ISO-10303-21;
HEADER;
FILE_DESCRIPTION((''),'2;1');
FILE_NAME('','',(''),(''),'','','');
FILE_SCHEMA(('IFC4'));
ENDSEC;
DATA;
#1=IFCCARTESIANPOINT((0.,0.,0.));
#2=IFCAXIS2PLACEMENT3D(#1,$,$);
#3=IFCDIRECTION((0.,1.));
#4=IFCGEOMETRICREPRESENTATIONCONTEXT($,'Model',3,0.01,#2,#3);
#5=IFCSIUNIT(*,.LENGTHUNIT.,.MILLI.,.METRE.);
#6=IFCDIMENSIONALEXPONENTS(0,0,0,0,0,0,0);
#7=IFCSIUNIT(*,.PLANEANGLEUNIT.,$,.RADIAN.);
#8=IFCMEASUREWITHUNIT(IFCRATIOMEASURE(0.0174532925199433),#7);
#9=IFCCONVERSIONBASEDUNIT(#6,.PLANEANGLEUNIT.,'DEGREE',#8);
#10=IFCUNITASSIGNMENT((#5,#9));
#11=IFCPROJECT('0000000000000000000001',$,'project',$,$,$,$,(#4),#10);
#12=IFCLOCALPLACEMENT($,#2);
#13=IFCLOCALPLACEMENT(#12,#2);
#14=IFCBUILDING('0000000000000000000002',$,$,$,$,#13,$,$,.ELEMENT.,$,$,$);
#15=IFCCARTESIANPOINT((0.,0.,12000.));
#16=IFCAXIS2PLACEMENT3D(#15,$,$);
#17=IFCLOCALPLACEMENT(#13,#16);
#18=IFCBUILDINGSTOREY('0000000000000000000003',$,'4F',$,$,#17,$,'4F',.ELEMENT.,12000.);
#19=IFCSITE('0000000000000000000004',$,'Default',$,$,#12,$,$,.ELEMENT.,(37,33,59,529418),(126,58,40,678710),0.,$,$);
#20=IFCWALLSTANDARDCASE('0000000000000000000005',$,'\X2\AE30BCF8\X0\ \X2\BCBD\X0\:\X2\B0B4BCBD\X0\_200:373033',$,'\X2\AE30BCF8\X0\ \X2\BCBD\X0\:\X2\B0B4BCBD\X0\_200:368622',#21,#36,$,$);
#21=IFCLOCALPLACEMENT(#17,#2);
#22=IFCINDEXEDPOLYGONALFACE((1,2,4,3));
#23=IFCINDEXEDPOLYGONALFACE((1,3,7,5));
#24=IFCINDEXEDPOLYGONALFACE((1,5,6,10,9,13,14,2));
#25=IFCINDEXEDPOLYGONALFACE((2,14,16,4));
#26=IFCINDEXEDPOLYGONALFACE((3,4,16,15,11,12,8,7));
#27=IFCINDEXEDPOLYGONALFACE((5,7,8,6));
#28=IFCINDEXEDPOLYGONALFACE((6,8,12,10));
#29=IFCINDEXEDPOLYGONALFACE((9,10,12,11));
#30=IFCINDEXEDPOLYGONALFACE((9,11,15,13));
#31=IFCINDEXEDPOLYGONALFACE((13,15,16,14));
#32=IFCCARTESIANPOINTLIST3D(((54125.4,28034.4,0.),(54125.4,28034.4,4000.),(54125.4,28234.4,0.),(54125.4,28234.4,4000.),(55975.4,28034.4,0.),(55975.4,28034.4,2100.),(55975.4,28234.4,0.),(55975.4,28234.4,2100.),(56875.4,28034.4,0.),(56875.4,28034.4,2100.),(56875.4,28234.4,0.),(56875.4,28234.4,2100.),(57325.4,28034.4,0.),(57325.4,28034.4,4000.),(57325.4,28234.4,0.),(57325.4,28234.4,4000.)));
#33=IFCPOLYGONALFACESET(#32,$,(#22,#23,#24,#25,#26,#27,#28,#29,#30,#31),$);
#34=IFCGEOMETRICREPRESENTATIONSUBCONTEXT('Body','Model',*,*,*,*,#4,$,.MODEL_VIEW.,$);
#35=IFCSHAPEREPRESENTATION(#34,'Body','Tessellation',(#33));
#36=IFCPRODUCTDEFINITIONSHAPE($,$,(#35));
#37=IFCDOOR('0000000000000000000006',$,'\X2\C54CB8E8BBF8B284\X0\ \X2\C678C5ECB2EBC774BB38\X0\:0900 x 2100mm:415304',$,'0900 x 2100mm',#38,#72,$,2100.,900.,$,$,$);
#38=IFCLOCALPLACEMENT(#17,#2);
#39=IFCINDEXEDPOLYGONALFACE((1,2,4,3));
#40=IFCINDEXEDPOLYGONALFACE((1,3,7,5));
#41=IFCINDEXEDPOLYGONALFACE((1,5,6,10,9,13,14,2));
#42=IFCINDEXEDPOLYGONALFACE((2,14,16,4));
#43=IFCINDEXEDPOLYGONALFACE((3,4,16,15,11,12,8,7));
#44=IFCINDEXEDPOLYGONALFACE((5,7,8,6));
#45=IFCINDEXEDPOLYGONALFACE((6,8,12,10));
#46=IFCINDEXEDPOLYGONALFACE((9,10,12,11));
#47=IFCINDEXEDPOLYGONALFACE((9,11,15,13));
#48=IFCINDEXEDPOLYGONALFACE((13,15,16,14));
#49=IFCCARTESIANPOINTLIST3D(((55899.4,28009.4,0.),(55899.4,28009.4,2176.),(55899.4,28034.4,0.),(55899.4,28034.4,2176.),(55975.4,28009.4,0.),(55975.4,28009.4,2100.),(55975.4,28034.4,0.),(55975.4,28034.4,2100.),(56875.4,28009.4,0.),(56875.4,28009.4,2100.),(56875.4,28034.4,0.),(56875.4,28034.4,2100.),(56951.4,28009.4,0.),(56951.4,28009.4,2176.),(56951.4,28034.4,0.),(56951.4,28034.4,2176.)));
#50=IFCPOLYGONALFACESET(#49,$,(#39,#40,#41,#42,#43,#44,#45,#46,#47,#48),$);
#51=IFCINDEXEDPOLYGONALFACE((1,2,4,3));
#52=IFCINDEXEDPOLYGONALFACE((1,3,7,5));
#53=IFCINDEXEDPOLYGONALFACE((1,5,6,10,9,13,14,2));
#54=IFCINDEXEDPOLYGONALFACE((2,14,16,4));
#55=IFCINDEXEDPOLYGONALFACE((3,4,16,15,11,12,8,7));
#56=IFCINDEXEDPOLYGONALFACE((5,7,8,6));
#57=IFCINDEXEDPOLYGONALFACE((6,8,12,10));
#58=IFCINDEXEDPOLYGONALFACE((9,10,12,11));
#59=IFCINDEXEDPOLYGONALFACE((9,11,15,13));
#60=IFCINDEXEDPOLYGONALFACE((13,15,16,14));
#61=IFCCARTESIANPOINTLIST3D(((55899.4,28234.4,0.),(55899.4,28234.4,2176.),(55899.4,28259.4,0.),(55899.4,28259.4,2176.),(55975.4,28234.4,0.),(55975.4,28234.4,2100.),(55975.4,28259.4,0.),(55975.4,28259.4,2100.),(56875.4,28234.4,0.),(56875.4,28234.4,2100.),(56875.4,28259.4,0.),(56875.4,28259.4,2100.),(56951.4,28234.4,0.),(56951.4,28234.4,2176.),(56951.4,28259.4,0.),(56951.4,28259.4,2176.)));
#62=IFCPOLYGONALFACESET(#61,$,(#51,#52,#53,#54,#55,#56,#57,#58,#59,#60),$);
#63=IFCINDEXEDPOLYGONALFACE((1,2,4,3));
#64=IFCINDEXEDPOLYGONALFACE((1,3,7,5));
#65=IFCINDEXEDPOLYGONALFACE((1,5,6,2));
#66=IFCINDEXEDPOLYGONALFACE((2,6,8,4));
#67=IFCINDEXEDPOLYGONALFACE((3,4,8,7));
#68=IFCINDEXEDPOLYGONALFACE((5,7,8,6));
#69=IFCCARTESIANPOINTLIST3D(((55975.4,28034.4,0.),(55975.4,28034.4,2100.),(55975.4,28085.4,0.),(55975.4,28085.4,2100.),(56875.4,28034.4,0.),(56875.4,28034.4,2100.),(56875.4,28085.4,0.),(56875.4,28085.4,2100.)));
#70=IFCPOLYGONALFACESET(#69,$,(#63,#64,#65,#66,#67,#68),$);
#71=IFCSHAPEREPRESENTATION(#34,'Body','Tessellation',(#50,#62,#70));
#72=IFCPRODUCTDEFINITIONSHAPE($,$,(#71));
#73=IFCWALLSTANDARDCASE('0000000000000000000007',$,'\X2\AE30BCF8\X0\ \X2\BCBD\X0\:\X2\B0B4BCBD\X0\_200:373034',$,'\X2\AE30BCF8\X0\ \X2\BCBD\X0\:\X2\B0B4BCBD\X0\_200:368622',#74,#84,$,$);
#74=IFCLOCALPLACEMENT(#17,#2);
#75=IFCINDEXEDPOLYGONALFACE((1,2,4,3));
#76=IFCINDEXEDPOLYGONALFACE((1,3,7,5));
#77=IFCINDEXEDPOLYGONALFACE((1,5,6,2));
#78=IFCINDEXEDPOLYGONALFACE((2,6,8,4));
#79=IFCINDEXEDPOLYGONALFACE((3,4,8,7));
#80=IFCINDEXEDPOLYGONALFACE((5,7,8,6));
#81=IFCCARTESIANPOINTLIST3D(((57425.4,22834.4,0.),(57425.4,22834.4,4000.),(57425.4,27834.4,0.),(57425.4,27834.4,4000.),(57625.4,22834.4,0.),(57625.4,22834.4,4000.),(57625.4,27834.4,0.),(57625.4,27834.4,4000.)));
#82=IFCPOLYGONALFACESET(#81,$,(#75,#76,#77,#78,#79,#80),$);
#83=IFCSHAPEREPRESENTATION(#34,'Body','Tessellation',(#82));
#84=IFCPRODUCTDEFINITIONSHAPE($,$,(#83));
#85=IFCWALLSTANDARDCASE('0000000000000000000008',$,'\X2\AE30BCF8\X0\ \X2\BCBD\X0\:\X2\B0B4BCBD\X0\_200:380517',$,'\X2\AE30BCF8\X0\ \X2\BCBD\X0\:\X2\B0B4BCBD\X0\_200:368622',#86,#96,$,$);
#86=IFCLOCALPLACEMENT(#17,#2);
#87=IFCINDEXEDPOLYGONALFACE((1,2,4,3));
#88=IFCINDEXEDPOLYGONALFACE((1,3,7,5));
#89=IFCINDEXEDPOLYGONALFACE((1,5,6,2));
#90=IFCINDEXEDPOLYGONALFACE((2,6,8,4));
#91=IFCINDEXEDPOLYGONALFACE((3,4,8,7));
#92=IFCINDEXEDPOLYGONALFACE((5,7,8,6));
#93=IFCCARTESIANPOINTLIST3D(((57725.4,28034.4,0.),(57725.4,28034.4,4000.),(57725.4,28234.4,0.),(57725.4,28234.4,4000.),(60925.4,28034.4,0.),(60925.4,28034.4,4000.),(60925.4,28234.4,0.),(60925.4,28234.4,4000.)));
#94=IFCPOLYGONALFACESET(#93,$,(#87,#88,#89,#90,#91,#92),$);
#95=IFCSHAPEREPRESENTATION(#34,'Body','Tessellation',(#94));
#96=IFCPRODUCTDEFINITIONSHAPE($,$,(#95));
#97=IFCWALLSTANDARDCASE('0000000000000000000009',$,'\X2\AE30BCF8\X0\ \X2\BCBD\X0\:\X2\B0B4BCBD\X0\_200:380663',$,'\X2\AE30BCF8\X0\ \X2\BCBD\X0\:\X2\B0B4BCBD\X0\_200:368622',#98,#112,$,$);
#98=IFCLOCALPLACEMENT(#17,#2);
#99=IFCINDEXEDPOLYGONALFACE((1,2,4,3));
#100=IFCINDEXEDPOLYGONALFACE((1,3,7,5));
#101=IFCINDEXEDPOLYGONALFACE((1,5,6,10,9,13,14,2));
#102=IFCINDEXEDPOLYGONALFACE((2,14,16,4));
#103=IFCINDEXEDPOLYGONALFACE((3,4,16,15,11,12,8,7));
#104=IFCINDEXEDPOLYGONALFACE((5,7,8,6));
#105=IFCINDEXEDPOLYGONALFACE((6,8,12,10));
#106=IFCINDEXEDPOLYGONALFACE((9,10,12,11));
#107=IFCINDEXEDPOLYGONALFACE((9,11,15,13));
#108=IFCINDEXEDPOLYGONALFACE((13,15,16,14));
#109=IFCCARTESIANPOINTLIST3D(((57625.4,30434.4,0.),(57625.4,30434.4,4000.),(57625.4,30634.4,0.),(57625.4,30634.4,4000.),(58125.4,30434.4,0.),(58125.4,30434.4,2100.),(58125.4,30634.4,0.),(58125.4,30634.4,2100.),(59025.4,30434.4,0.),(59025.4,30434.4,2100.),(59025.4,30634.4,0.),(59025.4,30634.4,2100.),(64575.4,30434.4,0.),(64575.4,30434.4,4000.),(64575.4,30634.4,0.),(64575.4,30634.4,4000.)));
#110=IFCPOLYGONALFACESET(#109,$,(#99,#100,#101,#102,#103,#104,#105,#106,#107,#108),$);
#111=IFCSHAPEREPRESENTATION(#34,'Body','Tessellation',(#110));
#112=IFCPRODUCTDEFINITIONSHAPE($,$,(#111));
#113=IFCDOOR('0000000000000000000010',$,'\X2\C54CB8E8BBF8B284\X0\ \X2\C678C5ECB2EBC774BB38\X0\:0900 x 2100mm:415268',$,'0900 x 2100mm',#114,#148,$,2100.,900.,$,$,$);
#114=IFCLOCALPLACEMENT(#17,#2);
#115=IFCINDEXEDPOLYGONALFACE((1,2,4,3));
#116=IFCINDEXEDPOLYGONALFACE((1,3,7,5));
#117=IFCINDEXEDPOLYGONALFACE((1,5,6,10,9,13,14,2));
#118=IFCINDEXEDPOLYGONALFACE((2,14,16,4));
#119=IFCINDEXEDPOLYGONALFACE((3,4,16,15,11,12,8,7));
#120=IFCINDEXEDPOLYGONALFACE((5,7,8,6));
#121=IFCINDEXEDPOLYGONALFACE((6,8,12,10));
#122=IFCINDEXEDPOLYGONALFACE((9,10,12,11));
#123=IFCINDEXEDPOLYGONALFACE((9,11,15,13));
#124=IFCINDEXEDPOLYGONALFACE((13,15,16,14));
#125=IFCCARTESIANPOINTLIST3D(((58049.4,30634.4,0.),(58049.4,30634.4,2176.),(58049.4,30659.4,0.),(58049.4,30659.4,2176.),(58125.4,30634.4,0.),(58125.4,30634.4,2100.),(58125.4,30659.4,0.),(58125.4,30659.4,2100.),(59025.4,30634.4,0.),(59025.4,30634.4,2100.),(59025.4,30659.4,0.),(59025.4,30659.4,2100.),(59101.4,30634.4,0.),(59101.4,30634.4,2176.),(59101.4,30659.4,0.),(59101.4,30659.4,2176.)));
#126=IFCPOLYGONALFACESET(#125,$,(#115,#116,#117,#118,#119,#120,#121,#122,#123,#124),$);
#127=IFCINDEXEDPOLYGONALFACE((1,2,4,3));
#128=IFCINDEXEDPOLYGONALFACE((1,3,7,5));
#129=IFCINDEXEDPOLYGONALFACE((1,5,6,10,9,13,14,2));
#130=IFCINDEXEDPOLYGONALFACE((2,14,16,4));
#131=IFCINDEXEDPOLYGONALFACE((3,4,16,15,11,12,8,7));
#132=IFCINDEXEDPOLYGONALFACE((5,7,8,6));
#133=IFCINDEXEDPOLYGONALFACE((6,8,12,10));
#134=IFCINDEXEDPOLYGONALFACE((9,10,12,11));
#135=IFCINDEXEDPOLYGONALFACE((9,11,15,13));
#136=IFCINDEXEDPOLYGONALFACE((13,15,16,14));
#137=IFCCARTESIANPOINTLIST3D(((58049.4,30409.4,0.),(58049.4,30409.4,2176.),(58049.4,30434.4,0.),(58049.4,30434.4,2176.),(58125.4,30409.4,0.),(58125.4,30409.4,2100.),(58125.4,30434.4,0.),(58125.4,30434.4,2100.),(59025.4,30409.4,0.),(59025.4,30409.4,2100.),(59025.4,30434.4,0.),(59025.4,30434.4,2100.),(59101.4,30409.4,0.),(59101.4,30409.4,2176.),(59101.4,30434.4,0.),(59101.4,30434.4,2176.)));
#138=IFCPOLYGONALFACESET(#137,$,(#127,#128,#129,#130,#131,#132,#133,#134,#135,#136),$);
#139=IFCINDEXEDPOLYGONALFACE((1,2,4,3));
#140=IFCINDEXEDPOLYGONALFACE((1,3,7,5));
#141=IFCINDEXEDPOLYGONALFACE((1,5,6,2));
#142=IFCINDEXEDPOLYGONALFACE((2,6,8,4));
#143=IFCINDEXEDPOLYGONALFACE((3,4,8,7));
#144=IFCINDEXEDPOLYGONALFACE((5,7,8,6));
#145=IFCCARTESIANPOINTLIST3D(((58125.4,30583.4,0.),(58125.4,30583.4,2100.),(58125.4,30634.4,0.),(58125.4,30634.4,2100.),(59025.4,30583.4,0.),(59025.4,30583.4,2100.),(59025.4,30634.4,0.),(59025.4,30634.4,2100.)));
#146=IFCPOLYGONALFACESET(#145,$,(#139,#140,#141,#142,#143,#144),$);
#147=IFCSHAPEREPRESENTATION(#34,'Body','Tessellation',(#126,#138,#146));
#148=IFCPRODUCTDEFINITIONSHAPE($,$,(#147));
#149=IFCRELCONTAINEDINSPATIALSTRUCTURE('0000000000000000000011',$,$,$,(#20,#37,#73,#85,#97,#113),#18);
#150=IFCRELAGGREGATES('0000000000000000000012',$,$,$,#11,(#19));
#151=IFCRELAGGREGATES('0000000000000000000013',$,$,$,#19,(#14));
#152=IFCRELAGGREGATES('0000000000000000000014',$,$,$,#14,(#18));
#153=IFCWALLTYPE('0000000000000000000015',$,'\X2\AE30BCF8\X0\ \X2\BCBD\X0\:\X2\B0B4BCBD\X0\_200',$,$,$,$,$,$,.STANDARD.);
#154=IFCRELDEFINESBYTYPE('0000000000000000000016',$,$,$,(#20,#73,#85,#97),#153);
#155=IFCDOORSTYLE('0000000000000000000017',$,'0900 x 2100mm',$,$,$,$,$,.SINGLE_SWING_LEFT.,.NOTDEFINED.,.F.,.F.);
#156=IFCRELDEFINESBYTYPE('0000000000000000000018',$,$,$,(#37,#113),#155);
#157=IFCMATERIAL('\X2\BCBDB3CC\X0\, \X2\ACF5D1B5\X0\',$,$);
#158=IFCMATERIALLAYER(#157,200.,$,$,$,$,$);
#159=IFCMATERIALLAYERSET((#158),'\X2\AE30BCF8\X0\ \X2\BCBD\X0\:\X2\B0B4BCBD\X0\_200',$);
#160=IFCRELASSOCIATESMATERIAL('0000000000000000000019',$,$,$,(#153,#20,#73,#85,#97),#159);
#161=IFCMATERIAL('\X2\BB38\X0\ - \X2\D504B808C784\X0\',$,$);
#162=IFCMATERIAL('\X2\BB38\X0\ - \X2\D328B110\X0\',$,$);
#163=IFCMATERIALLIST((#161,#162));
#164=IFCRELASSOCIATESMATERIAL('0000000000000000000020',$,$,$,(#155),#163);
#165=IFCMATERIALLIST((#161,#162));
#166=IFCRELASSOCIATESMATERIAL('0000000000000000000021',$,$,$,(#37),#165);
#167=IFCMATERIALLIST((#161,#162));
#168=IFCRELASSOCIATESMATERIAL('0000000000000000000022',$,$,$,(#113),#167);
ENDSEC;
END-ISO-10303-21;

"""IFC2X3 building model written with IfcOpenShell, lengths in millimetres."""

from ifc_helpers import new_model, entity, si_unit, converted_unit, direction, frame, frame_2d, origin, place, context, subcontext, project, spatial, polyline, rectangle, outline, extrude, source, transform, mapped, material, material_list, layer, layer_set, layer_usage, type_object, type_shapes, element, fill, save


model = new_model("IFC2X3")

# Units and contexts
model_context = context("Model", 3, precision=0.01, world=origin(), true_north=direction((0.0, 1.0)))
body_context = subcontext(model_context, "Body", "Model", "MODEL_VIEW")
ifc_project = project(units=[si_unit("LENGTHUNIT", "METRE", prefix="MILLI"), converted_unit("PLANEANGLEUNIT", "DEGREE", entity("IfcRatioMeasure", 0.0174532925199433), si_unit("PLANEANGLEUNIT", "RADIAN"), dimensions=[0, 0, 0, 0, 0, 0, 0])], contexts=[model_context])

# Site, building, storey
site_placement = place(None, origin())
site = spatial("IfcSite", under=ifc_project, at=site_placement, Name="Default", CompositionType="ELEMENT", RefLatitude=(37, 33, 59, 529418), RefLongitude=(126, 58, 40, 678710), RefElevation=0.0)
building_placement = place(site_placement, origin())
building = spatial("IfcBuilding", under=site, at=building_placement, CompositionType="ELEMENT")
storey_placement = place(building_placement, frame((0.0, 0.0, 12000.0)))
storey = spatial("IfcBuildingStorey", under=building, at=storey_placement, Name="4F", LongName="4F", CompositionType="ELEMENT", Elevation=12000.0)

# Wall, opening, door
ifc_material_1 = material(Name="벽돌, 공통")
ifc_layer_1 = layer(ifc_material_1, 200.0)
ifc_layer_set_1 = layer_set([ifc_layer_1], Name="기본 벽:내벽_200")
ifc_layer_usage_1 = layer_usage(ifc_layer_set_1, "AXIS2", "NEGATIVE", 100.0)
wall_type_1 = type_object("IfcWallType", Name="기본 벽:내벽_200", PredefinedType="STANDARD", material=ifc_layer_set_1)
wall_1_placement = place(storey_placement, frame((57325.4, 28134.4, 0.0), z_axis=(0.0, 0.0, 1.0), x_axis=(-1.0, 0.0, 0.0)))
wall_1 = element("IfcWallStandardCase", 1, at=wall_1_placement, inside=storey, type_object=wall_type_1, material=ifc_layer_usage_1, Name="기본 벽:내벽_200:373033", ObjectType="기본 벽:내벽_200:368622", context=body_context, shape_type="SweptSolid", body=[
    extrude(rectangle(XDim=3200.0, YDim=200.0, at=frame_2d((1600.0, 0.0), x_axis=(-1.0, 0.0))), origin(), (0.0, 0.0, 1.0), 4000.0),
])
opening_1_placement = place(wall_1_placement, frame((450.0, -100.0, 0.0)))
opening_1 = element("IfcOpeningElement", 2, at=opening_1_placement, cuts=wall_1, ObjectType="Opening", context=body_context, shape_type="SweptSolid", body=[
    extrude(rectangle(XDim=900.0, YDim=2100.0, at=frame_2d((1050.0, 450.0), x_axis=(0.0, -1.0))), frame((0.0, 0.0, 0.0), z_axis=(0.0, 1.0, 0.0), x_axis=(0.0, 0.0, 1.0)), (0.0, 0.0, 1.0), 200.0),
])
ifc_material_2 = material(Name="문 - 프레임")
ifc_material_3 = material(Name="문 - 패널")
ifc_material_list_1 = material_list([ifc_material_2, ifc_material_3])
ifc_material_list_2 = material_list([ifc_material_2, ifc_material_3])
door_style_1 = type_object("IfcDoorStyle", Name="0900 x 2100mm", ConstructionType="NOTDEFINED", OperationType="SINGLE_SWING_LEFT", ParameterTakesPrecedence=False, Sizeable=False, material=ifc_material_list_2)
shared_shape_1 = source(origin(), body_context, "Body", "SweptSolid", [
    extrude(outline(polyline([(-526.0, -1107.0), (526.0, -1107.0), (526.0, 1069.0), (450.0, 1069.0), (450.0, -1031.0), (-450.0, -1031.0), (-450.0, 1069.0), (-526.0, 1069.0), (-526.0, -1107.0)])), frame((450.0, 225.0, 1069.0), z_axis=(0.0, -1.0, 0.0), x_axis=(-1.0, 0.0, 0.0)), (0.0, 0.0, 1.0), 25.0),
    extrude(outline(polyline([(-1107.0, -526.0), (1069.0, -526.0), (1069.0, -450.0), (-1031.0, -450.0), (-1031.0, 450.0), (1069.0, 450.0), (1069.0, 526.0), (-1107.0, 526.0), (-1107.0, -526.0)])), frame((450.0, 0.0, 1069.0), z_axis=(0.0, -1.0, 0.0), x_axis=(0.0, 0.0, -1.0)), (0.0, 0.0, 1.0), 25.0),
    extrude(rectangle(XDim=900.0, YDim=51.0, at=frame_2d((0.0, 0.0), x_axis=(1.0, 0.0))), frame((450.0, 174.5, 0.0)), (0.0, 0.0, 1.0), 2100.0),
])
type_shapes(door_style_1, [shared_shape_1])
door_1_placement = place(opening_1_placement, frame((0.0, 0.0, 0.0)))
door_1 = element("IfcDoor", 3, at=door_1_placement, inside=storey, type_object=door_style_1, material=ifc_material_list_1, Name="알루미늄 외여닫이문:0900 x 2100mm:415304", ObjectType="0900 x 2100mm", OverallHeight=2100.0, OverallWidth=900.0, context=body_context, shape_type="MappedRepresentation", body=[
    mapped(shared_shape_1, transform((0.0, 0.0, 0.0), scale=1.0)),
])
fill(opening_1, door_1)

# Walls
ifc_layer_usage_2 = layer_usage(ifc_layer_set_1, "AXIS2", "NEGATIVE", 100.0)
wall_2_placement = place(storey_placement, frame((57525.4, 27834.4, 0.0), z_axis=(0.0, 0.0, 1.0), x_axis=(0.0, -1.0, 0.0)))
element("IfcWallStandardCase", 4, at=wall_2_placement, inside=storey, type_object=wall_type_1, material=ifc_layer_usage_2, Name="기본 벽:내벽_200:373034", ObjectType="기본 벽:내벽_200:368622", context=body_context, shape_type="SweptSolid", body=[
    extrude(rectangle(XDim=5000.0, YDim=200.0, at=frame_2d((2500.0, 0.0), x_axis=(-1.0, 0.0))), origin(), (0.0, 0.0, 1.0), 4000.0),
])
ifc_layer_usage_3 = layer_usage(ifc_layer_set_1, "AXIS2", "NEGATIVE", 100.0)
wall_3_placement = place(storey_placement, frame((57725.4, 28134.4, 0.0)))
element("IfcWallStandardCase", 5, at=wall_3_placement, inside=storey, type_object=wall_type_1, material=ifc_layer_usage_3, Name="기본 벽:내벽_200:380517", ObjectType="기본 벽:내벽_200:368622", context=body_context, shape_type="SweptSolid", body=[
    extrude(rectangle(XDim=3200.0, YDim=200.0, at=frame_2d((1600.0, 0.0), x_axis=(-1.0, 0.0))), origin(), (0.0, 0.0, 1.0), 4000.0),
])

# Wall, opening, door
ifc_layer_usage_4 = layer_usage(ifc_layer_set_1, "AXIS2", "NEGATIVE", 100.0)
wall_4_placement = place(storey_placement, frame((57625.4, 30534.4, 0.0)))
wall_4 = element("IfcWallStandardCase", 6, at=wall_4_placement, inside=storey, type_object=wall_type_1, material=ifc_layer_usage_4, Name="기본 벽:내벽_200:380663", ObjectType="기본 벽:내벽_200:368622", context=body_context, shape_type="SweptSolid", body=[
    extrude(rectangle(XDim=6950.0, YDim=200.0, at=frame_2d((3475.0, 0.0), x_axis=(-1.0, 0.0))), origin(), (0.0, 0.0, 1.0), 4000.0),
])
opening_2_placement = place(wall_4_placement, frame((500.0, -100.0, 0.0)))
opening_2 = element("IfcOpeningElement", 7, at=opening_2_placement, cuts=wall_4, ObjectType="Opening", context=body_context, shape_type="SweptSolid", body=[
    extrude(rectangle(XDim=900.0, YDim=2100.0, at=frame_2d((1050.0, 450.0), x_axis=(0.0, -1.0))), frame((0.0, 0.0, 0.0), z_axis=(0.0, 1.0, 0.0), x_axis=(0.0, 0.0, 1.0)), (0.0, 0.0, 1.0), 200.0),
])
ifc_material_list_3 = material_list([ifc_material_2, ifc_material_3])
door_2_placement = place(opening_2_placement, frame((0.0, 0.0, 0.0)))
door_2 = element("IfcDoor", 8, at=door_2_placement, inside=storey, type_object=door_style_1, material=ifc_material_list_3, Name="알루미늄 외여닫이문:0900 x 2100mm:415268", ObjectType="0900 x 2100mm", OverallHeight=2100.0, OverallWidth=900.0, context=body_context, shape_type="MappedRepresentation", body=[
    mapped(shared_shape_1, transform((0.0, 0.0, 0.0), scale=1.0)),
])
fill(opening_2, door_2)

save(model, "model.ifc")
